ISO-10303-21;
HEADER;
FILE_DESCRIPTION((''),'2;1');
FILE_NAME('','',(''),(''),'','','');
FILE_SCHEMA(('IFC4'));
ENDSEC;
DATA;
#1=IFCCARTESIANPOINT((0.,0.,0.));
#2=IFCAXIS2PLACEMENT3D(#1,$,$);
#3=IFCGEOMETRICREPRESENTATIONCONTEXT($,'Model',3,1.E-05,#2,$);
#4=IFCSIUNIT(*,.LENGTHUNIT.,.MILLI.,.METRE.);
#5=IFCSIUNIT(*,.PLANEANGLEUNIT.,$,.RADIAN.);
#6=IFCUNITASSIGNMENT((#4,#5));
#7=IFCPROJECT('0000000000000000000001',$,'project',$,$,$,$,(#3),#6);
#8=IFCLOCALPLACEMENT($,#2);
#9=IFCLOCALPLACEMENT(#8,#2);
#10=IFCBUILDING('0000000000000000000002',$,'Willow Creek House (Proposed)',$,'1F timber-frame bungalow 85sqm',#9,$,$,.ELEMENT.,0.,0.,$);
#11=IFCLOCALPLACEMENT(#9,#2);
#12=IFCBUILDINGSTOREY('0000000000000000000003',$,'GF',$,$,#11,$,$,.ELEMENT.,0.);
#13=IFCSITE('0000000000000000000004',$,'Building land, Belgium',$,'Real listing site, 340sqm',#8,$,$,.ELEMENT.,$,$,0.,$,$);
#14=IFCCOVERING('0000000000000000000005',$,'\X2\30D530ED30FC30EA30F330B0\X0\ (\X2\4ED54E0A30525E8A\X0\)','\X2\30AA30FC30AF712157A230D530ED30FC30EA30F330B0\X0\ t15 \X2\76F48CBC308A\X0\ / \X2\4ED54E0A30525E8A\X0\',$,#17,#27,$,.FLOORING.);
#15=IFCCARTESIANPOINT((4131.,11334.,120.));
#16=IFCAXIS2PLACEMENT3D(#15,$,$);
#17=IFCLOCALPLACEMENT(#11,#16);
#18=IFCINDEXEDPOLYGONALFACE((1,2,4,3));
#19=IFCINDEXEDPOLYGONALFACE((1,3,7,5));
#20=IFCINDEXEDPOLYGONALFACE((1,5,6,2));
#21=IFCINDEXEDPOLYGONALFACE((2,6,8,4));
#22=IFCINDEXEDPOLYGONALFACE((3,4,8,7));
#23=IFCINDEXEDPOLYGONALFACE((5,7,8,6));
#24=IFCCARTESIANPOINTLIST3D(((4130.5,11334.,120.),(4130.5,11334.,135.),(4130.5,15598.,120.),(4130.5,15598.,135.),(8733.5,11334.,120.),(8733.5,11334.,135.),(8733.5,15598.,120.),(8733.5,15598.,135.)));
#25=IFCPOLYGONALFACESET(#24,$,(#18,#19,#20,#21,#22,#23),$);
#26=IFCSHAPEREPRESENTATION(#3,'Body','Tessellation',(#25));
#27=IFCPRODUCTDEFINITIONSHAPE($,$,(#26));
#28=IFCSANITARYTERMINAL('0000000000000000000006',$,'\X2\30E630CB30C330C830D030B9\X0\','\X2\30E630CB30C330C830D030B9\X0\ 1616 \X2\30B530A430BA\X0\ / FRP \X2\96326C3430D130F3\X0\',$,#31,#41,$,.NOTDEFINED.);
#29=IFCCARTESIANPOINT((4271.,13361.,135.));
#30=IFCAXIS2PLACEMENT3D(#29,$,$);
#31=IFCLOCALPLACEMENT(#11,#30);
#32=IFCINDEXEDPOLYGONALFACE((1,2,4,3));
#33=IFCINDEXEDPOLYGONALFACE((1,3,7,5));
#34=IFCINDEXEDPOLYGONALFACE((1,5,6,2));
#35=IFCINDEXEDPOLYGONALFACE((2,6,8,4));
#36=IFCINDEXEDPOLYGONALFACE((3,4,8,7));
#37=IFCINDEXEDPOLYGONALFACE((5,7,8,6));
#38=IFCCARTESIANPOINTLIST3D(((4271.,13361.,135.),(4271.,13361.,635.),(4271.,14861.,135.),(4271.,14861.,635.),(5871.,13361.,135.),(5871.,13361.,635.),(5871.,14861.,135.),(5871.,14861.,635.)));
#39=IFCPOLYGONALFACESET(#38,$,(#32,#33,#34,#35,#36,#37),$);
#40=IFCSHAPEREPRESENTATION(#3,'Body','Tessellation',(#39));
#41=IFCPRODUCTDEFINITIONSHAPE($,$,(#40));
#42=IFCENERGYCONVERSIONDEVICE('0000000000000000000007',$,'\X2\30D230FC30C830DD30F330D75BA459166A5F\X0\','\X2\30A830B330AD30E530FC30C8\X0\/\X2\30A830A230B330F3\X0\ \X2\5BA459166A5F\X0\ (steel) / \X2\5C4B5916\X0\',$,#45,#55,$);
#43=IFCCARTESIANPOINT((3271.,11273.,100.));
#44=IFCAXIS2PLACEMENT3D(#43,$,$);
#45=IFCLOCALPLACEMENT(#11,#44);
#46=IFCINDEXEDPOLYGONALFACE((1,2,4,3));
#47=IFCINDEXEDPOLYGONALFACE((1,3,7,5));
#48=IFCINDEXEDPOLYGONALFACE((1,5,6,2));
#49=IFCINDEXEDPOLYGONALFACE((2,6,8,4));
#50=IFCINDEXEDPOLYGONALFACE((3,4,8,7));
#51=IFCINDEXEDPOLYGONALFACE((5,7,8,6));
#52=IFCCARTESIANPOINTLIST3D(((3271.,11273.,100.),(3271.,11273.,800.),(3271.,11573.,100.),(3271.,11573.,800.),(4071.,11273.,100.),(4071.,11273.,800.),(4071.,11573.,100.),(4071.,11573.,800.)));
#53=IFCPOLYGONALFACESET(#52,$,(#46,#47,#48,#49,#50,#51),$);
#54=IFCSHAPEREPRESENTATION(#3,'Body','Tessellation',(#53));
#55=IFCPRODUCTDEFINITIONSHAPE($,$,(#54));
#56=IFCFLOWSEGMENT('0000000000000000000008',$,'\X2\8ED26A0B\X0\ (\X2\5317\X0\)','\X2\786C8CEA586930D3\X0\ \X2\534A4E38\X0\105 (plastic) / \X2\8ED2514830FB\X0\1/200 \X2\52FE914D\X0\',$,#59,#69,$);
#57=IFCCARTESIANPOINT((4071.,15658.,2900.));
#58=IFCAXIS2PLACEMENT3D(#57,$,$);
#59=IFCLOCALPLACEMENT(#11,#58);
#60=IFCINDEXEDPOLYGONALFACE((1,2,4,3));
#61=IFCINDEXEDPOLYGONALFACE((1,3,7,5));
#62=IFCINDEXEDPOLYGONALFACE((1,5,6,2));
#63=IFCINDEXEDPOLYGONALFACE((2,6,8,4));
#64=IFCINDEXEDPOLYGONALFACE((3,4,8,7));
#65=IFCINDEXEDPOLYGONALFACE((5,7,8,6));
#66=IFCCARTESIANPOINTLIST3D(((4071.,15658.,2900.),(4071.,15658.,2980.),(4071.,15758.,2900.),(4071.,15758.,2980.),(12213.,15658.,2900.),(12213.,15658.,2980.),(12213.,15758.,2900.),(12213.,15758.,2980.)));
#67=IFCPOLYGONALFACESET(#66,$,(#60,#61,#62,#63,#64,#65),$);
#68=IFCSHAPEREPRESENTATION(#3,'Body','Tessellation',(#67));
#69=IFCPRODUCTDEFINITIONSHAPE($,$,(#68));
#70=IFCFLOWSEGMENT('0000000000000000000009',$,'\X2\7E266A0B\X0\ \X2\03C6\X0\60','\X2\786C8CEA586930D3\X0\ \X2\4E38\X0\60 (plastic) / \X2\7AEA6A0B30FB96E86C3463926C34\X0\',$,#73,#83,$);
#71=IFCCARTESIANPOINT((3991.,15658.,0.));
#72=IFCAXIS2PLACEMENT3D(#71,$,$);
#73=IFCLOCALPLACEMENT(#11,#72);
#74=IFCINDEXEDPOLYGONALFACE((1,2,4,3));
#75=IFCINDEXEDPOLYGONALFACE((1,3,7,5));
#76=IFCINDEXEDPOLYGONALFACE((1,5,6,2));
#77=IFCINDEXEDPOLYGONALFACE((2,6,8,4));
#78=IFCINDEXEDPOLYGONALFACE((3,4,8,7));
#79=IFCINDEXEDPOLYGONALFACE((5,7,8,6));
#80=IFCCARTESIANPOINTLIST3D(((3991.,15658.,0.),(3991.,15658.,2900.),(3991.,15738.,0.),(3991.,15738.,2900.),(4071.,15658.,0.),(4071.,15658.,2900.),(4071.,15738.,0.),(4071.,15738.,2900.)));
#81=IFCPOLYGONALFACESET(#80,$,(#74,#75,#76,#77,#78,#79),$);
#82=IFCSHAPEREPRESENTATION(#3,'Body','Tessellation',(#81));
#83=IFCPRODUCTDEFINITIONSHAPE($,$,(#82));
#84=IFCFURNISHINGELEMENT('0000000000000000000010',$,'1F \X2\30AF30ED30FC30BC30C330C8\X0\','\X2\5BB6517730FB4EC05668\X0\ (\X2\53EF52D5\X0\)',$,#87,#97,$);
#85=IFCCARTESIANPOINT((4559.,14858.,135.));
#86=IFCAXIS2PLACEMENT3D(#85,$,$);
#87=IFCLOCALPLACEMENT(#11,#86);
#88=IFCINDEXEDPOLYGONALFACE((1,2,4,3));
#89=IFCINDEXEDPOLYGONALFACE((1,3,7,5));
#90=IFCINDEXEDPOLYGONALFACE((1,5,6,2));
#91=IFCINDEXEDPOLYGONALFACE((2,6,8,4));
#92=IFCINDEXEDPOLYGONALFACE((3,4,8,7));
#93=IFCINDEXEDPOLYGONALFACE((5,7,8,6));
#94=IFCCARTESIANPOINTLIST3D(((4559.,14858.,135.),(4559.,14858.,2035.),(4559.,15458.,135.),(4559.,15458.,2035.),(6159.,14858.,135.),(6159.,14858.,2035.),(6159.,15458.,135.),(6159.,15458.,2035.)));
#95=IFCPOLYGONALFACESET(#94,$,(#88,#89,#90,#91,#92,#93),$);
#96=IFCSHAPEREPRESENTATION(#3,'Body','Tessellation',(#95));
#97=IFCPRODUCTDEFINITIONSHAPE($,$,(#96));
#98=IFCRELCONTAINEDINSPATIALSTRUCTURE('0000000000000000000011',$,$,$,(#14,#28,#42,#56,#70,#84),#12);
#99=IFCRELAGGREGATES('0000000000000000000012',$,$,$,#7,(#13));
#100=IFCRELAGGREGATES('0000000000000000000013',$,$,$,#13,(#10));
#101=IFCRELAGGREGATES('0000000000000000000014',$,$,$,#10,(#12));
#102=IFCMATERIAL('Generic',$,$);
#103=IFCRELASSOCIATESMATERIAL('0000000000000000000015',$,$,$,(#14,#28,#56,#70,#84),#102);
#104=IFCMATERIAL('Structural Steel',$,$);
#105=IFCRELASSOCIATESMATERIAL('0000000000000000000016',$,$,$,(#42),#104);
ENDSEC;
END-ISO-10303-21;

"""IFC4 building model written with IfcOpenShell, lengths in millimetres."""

from ifc_helpers import new_model, si_unit, frame, frame_2d, origin, place, context, project, spatial, rectangle, extrude, material, element, save


model = new_model("IFC4")

# Units and contexts
model_context = context("Model", 3, precision=1e-05, world=origin())
ifc_project = project(units=[si_unit("LENGTHUNIT", "METRE", prefix="MILLI"), si_unit("PLANEANGLEUNIT", "RADIAN")], contexts=[model_context])

# Site, building, storey
site_placement = place(None, origin())
site = spatial("IfcSite", under=ifc_project, at=site_placement, Name="Building land, Belgium", ObjectType="Real listing site, 340sqm", CompositionType="ELEMENT", RefElevation=0.0)
building_placement = place(site_placement, origin())
building = spatial("IfcBuilding", under=site, at=building_placement, Name="Willow Creek House (Proposed)", ObjectType="1F timber-frame bungalow 85sqm", CompositionType="ELEMENT", ElevationOfRefHeight=0.0, ElevationOfTerrain=0.0)
storey_placement = place(building_placement, origin())
storey = spatial("IfcBuildingStorey", under=building, at=storey_placement, Name="GF", CompositionType="ELEMENT", Elevation=0.0)

# Shared definitions
ifc_material_1 = material(Name="Structural Steel")

# Covering
ifc_material_2 = material(Name="Generic")
covering_placement = place(storey_placement, frame((4131.0, 11334.0, 120.0)))
element("IfcCovering", 1, at=covering_placement, inside=storey, material=ifc_material_2, Name="フローリング (仕上げ床)", Description="オーク無垢フローリング t15 直貼り / 仕上げ床", PredefinedType="FLOORING", context=model_context, shape_type="SweptSolid", body=[
    extrude(rectangle(XDim=4603.0, YDim=4264.0, at=frame_2d((2301.0, 2132.0))), frame((4131.0, 11334.0, 120.0)), (0.0, 0.0, 1.0), 15.0),
])

# Sanitary terminal
sanitary_terminal_placement = place(storey_placement, frame((4271.0, 13361.0, 135.0)))
element("IfcSanitaryTerminal", 2, at=sanitary_terminal_placement, inside=storey, material=ifc_material_2, Name="ユニットバス", Description="ユニットバス 1616 サイズ / FRP 防水パン", PredefinedType="NOTDEFINED", context=model_context, shape_type="SweptSolid", body=[
    extrude(rectangle(XDim=1600.0, YDim=1500.0, at=frame_2d((800.0, 750.0))), frame((4271.0, 13361.0, 135.0)), (0.0, 0.0, 1.0), 500.0),
])

# Energy conversion device
energy_conversion_device_placement = place(storey_placement, frame((3271.0, 11273.0, 100.0)))
element("IfcEnergyConversionDevice", 3, at=energy_conversion_device_placement, inside=storey, material=ifc_material_1, Name="ヒートポンプ室外機", Description="エコキュート/エアコン 室外機 (steel) / 屋外", context=model_context, shape_type="SweptSolid", body=[
    extrude(rectangle(XDim=800.0, YDim=300.0, at=frame_2d((400.0, 150.0))), frame((3271.0, 11273.0, 100.0)), (0.0, 0.0, 1.0), 700.0),
])

# Flow segments
flow_segment_1_placement = place(storey_placement, frame((4071.0, 15658.0, 2900.0)))
element("IfcFlowSegment", 4, at=flow_segment_1_placement, inside=storey, material=ifc_material_2, Name="軒樋 (北)", Description="硬質塩ビ 半丸105 (plastic) / 軒先・1/200 勾配", context=model_context, shape_type="SweptSolid", body=[
    extrude(rectangle(XDim=8142.0, YDim=100.0, at=frame_2d((4071.0, 50.0))), frame((4071.0, 15658.0, 2900.0)), (0.0, 0.0, 1.0), 80.0),
])
flow_segment_2_placement = place(storey_placement, frame((3991.0, 15658.0, 0.0)))
element("IfcFlowSegment", 5, at=flow_segment_2_placement, inside=storey, material=ifc_material_2, Name="縦樋 φ60", Description="硬質塩ビ 丸60 (plastic) / 竪樋・雨水排水", context=model_context, shape_type="SweptSolid", body=[
    extrude(rectangle(XDim=80.0, YDim=80.0, at=frame_2d((40.0, 40.0))), frame((3991.0, 15658.0, 0.0)), (0.0, 0.0, 1.0), 2900.0),
])

# Furnishing element
furnishing_placement = place(storey_placement, frame((4559.0, 14858.0, 135.0)))
element("IfcFurnishingElement", 6, at=furnishing_placement, inside=storey, material=ifc_material_2, Name="1F クローゼット", Description="家具・什器 (可動)", context=model_context, shape_type="SweptSolid", body=[
    extrude(rectangle(XDim=1600.0, YDim=600.0, at=frame_2d((800.0, 300.0))), frame((4559.0, 14858.0, 135.0)), (0.0, 0.0, 1.0), 1900.0),
])

save(model, "model.ifc")
